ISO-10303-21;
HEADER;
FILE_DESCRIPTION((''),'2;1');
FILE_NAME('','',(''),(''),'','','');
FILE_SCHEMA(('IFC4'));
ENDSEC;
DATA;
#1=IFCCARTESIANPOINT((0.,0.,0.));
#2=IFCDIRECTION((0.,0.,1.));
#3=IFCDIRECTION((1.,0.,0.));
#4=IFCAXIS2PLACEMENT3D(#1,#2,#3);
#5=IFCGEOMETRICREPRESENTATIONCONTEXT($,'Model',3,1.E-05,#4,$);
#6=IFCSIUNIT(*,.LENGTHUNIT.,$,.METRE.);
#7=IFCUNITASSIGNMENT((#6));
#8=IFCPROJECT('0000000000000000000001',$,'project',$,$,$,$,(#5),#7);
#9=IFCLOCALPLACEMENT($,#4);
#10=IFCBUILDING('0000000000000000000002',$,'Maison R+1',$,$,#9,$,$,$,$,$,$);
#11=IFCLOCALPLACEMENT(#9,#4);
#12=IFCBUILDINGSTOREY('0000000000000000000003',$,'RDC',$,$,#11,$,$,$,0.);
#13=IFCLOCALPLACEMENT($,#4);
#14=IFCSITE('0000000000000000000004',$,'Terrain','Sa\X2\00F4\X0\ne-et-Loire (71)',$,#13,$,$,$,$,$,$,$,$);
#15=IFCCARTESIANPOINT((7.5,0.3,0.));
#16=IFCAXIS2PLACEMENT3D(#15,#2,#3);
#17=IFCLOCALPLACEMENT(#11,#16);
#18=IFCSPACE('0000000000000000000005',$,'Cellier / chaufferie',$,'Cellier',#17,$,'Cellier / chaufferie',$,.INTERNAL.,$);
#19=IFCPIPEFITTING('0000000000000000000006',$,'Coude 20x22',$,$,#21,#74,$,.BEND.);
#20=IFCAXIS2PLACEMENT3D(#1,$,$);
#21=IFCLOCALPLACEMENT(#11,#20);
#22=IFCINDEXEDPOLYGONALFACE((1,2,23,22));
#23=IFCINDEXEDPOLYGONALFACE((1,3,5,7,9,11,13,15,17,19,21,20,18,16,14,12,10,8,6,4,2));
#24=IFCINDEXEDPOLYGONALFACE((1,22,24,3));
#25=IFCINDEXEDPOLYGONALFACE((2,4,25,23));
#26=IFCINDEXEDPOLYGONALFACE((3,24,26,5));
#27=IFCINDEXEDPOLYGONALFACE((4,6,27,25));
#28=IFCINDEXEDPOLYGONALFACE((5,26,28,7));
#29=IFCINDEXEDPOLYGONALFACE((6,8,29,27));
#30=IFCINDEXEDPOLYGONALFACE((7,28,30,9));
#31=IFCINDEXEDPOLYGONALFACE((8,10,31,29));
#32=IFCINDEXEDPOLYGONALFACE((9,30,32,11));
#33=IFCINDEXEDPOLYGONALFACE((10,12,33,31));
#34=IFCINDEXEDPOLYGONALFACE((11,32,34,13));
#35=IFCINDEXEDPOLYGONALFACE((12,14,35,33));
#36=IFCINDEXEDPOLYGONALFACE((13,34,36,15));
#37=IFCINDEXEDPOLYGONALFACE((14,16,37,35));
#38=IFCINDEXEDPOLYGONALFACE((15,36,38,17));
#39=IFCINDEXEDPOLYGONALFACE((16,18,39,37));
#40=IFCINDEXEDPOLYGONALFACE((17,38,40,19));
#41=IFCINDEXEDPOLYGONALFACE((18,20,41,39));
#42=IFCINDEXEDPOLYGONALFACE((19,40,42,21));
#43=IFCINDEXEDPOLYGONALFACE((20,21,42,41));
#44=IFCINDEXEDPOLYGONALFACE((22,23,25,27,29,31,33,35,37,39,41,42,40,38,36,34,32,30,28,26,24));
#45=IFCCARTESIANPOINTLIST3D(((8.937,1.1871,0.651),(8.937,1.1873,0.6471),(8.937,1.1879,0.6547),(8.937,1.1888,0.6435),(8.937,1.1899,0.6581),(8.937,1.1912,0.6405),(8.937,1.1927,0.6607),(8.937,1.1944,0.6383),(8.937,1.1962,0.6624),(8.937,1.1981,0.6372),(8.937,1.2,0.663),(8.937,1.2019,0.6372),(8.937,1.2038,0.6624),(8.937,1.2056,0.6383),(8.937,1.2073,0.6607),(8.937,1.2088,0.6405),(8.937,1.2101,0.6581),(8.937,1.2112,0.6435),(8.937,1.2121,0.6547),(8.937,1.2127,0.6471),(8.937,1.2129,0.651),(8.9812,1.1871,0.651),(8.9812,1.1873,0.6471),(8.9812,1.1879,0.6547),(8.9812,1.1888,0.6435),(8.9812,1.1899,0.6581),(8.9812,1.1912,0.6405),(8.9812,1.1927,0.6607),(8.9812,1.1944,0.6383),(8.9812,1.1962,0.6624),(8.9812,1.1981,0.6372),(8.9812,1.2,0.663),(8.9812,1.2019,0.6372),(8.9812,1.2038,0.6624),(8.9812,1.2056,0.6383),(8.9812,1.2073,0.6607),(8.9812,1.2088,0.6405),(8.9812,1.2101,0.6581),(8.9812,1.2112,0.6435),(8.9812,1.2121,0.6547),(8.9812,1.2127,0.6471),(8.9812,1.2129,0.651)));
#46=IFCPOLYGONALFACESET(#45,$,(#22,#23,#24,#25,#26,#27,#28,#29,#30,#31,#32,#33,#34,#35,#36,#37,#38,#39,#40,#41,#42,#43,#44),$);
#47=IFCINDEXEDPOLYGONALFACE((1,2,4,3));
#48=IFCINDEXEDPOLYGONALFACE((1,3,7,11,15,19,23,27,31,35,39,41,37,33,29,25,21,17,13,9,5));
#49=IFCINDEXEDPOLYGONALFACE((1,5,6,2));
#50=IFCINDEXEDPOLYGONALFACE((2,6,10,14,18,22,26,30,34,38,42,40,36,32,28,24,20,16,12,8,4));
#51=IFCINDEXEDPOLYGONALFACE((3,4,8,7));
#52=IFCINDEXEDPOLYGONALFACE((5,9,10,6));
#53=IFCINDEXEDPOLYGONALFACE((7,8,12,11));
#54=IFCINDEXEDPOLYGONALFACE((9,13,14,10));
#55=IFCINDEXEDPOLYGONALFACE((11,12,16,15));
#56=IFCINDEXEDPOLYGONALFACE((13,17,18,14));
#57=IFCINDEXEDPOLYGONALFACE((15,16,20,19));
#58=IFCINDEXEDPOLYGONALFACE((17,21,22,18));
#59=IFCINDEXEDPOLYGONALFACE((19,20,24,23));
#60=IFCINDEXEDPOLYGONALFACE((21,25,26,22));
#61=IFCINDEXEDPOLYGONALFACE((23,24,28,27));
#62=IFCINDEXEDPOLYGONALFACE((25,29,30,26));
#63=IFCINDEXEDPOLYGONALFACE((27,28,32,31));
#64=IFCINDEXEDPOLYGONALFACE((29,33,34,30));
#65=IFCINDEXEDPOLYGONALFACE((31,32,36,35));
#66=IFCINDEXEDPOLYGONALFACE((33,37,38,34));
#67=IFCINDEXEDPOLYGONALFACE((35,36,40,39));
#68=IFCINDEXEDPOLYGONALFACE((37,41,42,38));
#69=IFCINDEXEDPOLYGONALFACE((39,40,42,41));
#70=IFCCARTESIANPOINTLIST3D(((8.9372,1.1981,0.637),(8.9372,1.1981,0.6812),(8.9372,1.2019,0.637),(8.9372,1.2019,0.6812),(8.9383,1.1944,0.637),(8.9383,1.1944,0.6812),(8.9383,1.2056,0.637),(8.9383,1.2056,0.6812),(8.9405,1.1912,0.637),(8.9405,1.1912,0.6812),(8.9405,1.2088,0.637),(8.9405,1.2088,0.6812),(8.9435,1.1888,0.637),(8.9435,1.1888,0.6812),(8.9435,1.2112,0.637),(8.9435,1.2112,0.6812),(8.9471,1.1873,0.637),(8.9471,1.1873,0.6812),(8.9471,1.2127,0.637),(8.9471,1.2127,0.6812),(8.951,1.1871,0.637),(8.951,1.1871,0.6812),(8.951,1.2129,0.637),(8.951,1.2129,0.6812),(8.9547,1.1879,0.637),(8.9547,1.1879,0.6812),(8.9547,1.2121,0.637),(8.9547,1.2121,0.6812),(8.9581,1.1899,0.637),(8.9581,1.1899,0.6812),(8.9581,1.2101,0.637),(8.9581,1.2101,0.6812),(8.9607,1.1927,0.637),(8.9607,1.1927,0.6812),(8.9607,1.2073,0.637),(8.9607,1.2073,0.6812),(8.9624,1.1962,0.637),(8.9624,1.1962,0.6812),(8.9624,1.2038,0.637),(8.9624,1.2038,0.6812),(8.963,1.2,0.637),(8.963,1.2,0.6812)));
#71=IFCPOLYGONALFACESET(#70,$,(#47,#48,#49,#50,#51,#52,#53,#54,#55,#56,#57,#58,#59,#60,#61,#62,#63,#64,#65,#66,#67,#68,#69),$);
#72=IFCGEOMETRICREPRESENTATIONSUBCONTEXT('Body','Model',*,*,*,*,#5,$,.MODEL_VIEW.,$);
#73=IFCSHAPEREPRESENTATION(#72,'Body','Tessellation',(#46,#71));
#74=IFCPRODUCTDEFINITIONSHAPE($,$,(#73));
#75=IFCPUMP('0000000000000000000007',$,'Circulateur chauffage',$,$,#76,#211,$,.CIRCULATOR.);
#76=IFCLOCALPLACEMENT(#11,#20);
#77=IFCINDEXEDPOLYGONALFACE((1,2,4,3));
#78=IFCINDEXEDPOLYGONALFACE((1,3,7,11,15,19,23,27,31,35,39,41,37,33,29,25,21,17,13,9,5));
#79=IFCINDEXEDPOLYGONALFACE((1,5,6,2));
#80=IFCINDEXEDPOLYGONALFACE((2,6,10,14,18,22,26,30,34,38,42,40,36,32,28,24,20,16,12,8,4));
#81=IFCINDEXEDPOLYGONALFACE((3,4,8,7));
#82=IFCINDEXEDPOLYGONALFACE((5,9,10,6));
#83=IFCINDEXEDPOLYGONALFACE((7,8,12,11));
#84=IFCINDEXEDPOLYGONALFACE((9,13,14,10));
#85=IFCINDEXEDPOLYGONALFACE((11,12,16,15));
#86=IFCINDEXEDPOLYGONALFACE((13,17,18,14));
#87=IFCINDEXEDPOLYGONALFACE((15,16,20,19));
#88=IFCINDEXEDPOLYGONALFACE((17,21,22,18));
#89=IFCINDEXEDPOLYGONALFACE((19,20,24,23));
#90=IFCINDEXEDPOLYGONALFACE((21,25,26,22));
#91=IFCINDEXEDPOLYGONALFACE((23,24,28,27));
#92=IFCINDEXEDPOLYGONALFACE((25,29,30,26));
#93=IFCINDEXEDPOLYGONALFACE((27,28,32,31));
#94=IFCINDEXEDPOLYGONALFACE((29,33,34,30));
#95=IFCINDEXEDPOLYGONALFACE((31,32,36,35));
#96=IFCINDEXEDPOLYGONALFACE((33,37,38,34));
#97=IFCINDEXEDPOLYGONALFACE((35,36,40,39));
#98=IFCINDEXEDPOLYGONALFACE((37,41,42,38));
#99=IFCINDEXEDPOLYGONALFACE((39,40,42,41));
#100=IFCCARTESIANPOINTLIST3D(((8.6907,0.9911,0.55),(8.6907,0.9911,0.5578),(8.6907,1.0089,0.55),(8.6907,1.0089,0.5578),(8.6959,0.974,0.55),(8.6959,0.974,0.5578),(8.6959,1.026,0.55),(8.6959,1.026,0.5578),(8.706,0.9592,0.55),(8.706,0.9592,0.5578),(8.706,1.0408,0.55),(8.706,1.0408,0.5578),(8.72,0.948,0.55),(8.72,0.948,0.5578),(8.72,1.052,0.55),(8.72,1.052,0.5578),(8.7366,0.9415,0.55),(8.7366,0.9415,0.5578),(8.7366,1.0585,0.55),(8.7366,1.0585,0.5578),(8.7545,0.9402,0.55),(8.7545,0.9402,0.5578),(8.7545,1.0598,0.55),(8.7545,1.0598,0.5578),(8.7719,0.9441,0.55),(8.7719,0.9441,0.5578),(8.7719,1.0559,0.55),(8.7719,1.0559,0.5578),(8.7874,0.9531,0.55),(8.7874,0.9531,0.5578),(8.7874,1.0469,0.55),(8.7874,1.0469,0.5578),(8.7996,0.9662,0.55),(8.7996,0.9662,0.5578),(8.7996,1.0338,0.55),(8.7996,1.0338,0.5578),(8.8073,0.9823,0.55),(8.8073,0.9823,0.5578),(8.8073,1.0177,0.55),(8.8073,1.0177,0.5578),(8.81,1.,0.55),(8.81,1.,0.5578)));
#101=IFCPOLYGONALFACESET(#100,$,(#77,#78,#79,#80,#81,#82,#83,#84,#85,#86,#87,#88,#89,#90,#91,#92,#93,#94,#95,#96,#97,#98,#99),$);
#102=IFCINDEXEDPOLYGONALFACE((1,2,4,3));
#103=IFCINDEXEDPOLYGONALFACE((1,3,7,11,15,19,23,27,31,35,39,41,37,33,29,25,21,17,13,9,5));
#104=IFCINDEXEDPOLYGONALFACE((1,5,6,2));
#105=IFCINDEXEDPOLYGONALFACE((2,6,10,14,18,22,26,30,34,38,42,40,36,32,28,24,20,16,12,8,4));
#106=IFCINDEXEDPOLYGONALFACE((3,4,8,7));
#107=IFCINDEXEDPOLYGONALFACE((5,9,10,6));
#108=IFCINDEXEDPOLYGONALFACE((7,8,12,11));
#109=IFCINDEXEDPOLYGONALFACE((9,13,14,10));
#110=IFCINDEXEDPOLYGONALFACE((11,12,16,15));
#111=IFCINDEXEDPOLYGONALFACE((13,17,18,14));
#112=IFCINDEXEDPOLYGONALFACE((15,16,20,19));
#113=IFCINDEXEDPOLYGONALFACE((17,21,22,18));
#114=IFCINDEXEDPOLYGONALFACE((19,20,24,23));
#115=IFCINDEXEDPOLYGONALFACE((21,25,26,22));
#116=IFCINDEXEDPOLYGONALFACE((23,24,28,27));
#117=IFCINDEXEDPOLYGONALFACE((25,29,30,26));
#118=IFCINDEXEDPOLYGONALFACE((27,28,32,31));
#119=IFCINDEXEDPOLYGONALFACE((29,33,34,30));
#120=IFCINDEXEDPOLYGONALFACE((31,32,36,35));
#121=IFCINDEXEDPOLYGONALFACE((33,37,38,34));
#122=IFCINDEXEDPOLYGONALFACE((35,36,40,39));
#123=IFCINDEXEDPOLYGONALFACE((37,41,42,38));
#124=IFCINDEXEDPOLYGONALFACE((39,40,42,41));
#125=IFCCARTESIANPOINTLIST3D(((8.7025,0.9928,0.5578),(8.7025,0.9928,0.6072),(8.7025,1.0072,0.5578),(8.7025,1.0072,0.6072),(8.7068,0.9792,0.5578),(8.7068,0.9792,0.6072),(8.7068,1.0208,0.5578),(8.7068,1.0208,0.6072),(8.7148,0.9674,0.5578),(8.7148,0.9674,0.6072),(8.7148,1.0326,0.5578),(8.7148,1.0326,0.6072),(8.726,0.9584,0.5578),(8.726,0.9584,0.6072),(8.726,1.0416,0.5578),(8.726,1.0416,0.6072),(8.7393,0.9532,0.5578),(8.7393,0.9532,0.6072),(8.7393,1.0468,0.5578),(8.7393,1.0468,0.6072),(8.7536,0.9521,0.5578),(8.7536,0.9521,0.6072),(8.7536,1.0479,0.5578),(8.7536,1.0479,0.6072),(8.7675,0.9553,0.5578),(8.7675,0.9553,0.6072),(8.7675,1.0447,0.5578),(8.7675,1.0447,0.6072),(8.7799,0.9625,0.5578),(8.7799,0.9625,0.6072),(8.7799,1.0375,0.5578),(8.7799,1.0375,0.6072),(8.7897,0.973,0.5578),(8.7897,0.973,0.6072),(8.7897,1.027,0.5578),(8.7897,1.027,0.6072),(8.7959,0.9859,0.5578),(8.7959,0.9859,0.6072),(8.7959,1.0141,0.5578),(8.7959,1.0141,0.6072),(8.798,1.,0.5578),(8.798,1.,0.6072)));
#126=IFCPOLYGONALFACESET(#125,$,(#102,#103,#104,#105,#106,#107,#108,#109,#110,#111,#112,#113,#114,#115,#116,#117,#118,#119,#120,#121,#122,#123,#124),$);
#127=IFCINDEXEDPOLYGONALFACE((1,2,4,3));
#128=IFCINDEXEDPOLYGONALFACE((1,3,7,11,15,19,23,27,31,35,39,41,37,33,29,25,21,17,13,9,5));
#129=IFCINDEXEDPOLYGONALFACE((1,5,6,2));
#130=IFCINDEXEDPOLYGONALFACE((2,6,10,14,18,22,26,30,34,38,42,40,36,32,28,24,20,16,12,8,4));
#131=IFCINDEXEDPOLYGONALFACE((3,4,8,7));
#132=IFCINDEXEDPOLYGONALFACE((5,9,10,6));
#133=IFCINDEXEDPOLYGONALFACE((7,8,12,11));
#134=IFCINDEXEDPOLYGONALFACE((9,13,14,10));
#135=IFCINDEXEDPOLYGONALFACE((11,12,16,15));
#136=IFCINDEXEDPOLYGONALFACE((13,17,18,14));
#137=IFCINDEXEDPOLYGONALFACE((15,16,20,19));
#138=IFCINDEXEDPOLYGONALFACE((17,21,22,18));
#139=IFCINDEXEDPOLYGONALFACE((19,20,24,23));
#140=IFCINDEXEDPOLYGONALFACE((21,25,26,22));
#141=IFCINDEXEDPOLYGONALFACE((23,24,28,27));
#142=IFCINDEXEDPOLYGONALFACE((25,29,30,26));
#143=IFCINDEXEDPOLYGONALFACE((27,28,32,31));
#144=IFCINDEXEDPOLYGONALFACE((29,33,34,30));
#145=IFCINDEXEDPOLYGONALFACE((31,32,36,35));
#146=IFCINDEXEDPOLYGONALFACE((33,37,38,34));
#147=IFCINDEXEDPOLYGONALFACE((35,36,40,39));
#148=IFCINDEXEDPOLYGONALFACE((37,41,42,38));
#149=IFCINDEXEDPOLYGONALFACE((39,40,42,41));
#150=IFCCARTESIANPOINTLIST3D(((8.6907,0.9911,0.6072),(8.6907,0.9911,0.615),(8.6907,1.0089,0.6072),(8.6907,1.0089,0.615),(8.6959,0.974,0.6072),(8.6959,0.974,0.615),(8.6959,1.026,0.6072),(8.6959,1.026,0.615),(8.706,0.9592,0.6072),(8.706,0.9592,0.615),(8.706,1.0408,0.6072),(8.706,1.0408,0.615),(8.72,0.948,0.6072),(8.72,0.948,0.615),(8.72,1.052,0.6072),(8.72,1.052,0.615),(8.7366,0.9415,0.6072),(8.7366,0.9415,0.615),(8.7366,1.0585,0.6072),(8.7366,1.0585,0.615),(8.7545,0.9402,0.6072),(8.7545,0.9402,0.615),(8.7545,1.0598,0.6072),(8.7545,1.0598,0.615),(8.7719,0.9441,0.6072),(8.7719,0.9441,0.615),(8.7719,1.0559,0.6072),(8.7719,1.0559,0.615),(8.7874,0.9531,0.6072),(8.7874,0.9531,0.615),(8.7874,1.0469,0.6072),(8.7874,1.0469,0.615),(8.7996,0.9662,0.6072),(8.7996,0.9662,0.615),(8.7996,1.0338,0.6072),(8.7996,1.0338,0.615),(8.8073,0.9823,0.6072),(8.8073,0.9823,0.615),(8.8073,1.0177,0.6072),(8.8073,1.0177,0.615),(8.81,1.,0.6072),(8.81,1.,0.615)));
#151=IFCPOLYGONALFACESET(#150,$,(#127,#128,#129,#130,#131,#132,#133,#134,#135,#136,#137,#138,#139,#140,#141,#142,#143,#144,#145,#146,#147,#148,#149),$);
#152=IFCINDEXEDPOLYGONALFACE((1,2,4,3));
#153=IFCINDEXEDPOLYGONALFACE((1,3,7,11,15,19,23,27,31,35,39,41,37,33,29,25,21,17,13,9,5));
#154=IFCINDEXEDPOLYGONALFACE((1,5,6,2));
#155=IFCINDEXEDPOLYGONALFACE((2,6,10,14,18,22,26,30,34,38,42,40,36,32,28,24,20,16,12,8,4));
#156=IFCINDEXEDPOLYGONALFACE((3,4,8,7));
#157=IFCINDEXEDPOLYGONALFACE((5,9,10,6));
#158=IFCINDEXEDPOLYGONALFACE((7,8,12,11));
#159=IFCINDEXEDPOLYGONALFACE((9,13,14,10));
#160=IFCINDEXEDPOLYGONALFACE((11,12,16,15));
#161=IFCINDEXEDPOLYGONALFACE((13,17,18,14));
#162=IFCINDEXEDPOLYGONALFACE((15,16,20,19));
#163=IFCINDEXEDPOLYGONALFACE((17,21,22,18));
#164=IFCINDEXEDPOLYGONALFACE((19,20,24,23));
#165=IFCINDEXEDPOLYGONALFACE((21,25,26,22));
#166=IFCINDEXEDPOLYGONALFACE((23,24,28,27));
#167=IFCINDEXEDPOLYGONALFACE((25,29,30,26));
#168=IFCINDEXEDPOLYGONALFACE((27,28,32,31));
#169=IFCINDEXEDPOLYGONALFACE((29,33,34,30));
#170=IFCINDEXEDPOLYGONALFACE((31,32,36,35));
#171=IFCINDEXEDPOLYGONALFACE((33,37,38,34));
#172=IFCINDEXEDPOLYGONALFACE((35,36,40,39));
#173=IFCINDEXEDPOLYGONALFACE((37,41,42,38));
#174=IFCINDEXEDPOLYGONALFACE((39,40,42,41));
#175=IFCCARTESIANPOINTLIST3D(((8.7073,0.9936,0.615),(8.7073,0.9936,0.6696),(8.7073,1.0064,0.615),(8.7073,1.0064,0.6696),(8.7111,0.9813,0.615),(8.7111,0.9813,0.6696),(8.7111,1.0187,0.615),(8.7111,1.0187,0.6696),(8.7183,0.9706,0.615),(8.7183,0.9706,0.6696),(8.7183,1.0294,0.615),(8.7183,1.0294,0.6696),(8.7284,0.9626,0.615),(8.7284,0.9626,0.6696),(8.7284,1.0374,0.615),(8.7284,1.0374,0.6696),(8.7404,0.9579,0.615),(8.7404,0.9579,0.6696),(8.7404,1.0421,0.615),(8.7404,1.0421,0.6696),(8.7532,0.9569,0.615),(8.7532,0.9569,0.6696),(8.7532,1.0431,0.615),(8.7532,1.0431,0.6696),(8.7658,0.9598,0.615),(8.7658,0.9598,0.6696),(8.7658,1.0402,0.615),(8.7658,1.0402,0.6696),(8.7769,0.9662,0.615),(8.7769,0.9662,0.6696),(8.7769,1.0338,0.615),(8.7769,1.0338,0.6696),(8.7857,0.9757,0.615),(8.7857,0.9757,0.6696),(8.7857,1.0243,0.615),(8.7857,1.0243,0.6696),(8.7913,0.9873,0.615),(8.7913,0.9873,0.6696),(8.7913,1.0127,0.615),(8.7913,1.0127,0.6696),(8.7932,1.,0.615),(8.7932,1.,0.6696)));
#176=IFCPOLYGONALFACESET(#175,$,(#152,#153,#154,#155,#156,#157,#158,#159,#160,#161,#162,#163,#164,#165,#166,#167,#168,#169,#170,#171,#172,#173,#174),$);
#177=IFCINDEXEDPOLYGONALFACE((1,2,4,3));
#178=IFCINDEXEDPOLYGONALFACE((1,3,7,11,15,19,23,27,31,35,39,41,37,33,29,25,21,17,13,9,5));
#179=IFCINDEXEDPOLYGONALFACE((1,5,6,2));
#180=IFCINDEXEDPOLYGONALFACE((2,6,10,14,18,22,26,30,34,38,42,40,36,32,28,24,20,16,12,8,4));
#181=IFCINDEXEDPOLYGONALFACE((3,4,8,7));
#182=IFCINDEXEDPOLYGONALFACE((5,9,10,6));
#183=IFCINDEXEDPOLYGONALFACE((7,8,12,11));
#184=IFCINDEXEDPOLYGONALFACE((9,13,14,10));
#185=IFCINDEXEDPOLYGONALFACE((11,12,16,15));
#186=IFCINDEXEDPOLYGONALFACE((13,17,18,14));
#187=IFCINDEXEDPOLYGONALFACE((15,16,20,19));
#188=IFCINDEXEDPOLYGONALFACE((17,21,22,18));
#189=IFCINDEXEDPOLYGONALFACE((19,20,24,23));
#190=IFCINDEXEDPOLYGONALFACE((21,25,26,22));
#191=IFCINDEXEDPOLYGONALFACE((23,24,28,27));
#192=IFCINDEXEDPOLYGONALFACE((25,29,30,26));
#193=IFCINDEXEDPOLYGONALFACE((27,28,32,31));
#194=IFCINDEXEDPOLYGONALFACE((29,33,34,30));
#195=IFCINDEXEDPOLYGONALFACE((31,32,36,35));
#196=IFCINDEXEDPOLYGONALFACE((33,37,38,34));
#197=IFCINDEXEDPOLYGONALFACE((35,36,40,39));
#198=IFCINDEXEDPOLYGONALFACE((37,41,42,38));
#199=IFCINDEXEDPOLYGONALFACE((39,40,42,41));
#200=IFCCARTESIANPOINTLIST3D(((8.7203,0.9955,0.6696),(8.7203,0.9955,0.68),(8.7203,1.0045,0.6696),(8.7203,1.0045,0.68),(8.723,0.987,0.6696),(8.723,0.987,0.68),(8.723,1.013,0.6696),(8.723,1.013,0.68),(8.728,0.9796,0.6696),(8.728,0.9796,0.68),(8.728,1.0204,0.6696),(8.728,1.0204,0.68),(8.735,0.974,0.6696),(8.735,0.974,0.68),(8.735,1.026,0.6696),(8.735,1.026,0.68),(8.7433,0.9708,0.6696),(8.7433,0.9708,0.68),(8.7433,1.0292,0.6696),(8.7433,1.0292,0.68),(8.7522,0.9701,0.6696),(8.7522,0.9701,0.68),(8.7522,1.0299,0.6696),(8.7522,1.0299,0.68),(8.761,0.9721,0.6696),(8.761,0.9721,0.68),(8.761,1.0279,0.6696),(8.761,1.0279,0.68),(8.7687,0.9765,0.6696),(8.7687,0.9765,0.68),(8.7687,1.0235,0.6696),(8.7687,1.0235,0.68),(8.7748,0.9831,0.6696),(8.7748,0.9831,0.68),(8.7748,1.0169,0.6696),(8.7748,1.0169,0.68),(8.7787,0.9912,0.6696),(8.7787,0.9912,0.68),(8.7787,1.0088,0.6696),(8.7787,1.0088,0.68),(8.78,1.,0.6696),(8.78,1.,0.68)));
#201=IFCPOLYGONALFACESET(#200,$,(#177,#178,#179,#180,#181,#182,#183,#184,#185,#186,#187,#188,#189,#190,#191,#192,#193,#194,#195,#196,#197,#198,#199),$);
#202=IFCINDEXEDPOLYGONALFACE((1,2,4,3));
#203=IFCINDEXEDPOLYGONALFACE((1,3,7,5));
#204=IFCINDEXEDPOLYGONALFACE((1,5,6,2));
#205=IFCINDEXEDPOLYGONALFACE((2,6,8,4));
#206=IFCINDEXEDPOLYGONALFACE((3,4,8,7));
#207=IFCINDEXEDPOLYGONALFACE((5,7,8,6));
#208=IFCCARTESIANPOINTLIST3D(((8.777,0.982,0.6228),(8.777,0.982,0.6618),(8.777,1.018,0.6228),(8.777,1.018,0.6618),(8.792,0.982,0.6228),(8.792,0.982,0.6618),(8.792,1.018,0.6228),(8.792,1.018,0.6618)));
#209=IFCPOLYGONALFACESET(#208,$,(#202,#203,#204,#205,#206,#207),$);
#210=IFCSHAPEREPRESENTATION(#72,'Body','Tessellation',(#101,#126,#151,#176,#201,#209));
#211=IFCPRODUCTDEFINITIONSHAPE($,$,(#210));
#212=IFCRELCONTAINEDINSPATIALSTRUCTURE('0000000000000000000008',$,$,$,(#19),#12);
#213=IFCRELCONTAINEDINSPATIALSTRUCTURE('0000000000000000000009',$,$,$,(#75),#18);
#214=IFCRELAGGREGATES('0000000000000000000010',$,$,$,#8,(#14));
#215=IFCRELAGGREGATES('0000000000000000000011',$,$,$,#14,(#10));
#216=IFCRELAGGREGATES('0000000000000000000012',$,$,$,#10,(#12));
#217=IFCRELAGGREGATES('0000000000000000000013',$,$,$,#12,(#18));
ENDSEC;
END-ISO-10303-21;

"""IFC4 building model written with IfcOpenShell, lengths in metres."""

from ifc_helpers import new_model, si_unit, frame, frame_2d, origin_with_axes, place, context, subcontext, project, spatial, rectangle, circle, extrude, element, save


model = new_model("IFC4")

# Units and contexts
model_context = context("Model", 3, precision=1e-05, world=origin_with_axes())
body_context = subcontext(model_context, "Body", "Model", "MODEL_VIEW")
ifc_project = project(units=[si_unit("LENGTHUNIT", "METRE")], contexts=[model_context])

# Site, building, storey
site_placement = place(None, origin_with_axes())
site = spatial("IfcSite", under=ifc_project, at=site_placement, Name="Terrain", Description="Saône-et-Loire (71)")
building_placement = place(None, origin_with_axes())
building = spatial("IfcBuilding", under=site, at=building_placement, Name="Maison R+1")
storey_placement = place(building_placement, origin_with_axes())
storey = spatial("IfcBuildingStorey", under=building, at=storey_placement, Name="RDC", Elevation=0.0)

# Shared definitions
space_placement = place(storey_placement, frame((7.5, 0.3, 0.0), z_axis=(0.0, 0.0, 1.0), x_axis=(1.0, 0.0, 0.0)))
space = spatial("IfcSpace", under=storey, at=space_placement, Name="Cellier / chaufferie", ObjectType="Cellier", LongName="Cellier / chaufferie", PredefinedType="INTERNAL")

# Pipe fitting
for number, where, z_axis, x_axis, name in (
    (1, (8.95, 1.2, 0.65), (0.0, 0.0, 1.0), (1.0, 0.0, 0.0), "Coude 20x22"),
):
    element("IfcPipeFitting", number, at=place(storey_placement, frame(where, z_axis=z_axis, x_axis=x_axis)), inside=storey, Name=name, PredefinedType="BEND", context=body_context, shape_type="SweptSolid", body=[
        extrude(circle(Radius=0.013), frame((-0.013, 0.0, 0.0), z_axis=(1.0, 0.0, 0.0), x_axis=(0.0, 0.0, 1.0)), (0.0, 0.0, 1.0), 0.0441),
        extrude(circle(Radius=0.013), frame((0.0, 0.0, -0.013), z_axis=(0.0, 0.0, 1.0), x_axis=(1.0, 0.0, 0.0)), (0.0, 0.0, 1.0), 0.0441),
    ])

# Pump
pump_placement = place(space_placement, frame((1.25, 0.7, 0.55), z_axis=(0.0, 0.0, 1.0), x_axis=(1.0, 0.0, 0.0)))
element("IfcPump", 2, at=pump_placement, inside=space, Name="Circulateur chauffage", PredefinedType="CIRCULATOR", context=body_context, shape_type="SweptSolid", body=[
    extrude(circle(Radius=0.06), origin_with_axes(), (0.0, 0.0, 1.0), 0.0078),
    extrude(circle(Radius=0.048), frame((0.0, 0.0, 0.0078), z_axis=(0.0, 0.0, 1.0), x_axis=(1.0, 0.0, 0.0)), (0.0, 0.0, 1.0), 0.0494),
    extrude(circle(Radius=0.06), frame((0.0, 0.0, 0.0572), z_axis=(0.0, 0.0, 1.0), x_axis=(1.0, 0.0, 0.0)), (0.0, 0.0, 1.0), 0.0078),
    extrude(circle(Radius=0.0432), frame((0.0, 0.0, 0.065), z_axis=(0.0, 0.0, 1.0), x_axis=(1.0, 0.0, 0.0)), (0.0, 0.0, 1.0), 0.0546),
    extrude(circle(Radius=0.03), frame((0.0, 0.0, 0.1196), z_axis=(0.0, 0.0, 1.0), x_axis=(1.0, 0.0, 0.0)), (0.0, 0.0, 1.0), 0.0104),
    extrude(rectangle(XDim=0.015, YDim=0.036, at=frame_2d((0.0075, 0.018))), frame((0.027, -0.018, 0.0728), z_axis=(0.0, 0.0, 1.0), x_axis=(1.0, 0.0, 0.0)), (0.0, 0.0, 1.0), 0.039),
])

save(model, "model.ifc")
